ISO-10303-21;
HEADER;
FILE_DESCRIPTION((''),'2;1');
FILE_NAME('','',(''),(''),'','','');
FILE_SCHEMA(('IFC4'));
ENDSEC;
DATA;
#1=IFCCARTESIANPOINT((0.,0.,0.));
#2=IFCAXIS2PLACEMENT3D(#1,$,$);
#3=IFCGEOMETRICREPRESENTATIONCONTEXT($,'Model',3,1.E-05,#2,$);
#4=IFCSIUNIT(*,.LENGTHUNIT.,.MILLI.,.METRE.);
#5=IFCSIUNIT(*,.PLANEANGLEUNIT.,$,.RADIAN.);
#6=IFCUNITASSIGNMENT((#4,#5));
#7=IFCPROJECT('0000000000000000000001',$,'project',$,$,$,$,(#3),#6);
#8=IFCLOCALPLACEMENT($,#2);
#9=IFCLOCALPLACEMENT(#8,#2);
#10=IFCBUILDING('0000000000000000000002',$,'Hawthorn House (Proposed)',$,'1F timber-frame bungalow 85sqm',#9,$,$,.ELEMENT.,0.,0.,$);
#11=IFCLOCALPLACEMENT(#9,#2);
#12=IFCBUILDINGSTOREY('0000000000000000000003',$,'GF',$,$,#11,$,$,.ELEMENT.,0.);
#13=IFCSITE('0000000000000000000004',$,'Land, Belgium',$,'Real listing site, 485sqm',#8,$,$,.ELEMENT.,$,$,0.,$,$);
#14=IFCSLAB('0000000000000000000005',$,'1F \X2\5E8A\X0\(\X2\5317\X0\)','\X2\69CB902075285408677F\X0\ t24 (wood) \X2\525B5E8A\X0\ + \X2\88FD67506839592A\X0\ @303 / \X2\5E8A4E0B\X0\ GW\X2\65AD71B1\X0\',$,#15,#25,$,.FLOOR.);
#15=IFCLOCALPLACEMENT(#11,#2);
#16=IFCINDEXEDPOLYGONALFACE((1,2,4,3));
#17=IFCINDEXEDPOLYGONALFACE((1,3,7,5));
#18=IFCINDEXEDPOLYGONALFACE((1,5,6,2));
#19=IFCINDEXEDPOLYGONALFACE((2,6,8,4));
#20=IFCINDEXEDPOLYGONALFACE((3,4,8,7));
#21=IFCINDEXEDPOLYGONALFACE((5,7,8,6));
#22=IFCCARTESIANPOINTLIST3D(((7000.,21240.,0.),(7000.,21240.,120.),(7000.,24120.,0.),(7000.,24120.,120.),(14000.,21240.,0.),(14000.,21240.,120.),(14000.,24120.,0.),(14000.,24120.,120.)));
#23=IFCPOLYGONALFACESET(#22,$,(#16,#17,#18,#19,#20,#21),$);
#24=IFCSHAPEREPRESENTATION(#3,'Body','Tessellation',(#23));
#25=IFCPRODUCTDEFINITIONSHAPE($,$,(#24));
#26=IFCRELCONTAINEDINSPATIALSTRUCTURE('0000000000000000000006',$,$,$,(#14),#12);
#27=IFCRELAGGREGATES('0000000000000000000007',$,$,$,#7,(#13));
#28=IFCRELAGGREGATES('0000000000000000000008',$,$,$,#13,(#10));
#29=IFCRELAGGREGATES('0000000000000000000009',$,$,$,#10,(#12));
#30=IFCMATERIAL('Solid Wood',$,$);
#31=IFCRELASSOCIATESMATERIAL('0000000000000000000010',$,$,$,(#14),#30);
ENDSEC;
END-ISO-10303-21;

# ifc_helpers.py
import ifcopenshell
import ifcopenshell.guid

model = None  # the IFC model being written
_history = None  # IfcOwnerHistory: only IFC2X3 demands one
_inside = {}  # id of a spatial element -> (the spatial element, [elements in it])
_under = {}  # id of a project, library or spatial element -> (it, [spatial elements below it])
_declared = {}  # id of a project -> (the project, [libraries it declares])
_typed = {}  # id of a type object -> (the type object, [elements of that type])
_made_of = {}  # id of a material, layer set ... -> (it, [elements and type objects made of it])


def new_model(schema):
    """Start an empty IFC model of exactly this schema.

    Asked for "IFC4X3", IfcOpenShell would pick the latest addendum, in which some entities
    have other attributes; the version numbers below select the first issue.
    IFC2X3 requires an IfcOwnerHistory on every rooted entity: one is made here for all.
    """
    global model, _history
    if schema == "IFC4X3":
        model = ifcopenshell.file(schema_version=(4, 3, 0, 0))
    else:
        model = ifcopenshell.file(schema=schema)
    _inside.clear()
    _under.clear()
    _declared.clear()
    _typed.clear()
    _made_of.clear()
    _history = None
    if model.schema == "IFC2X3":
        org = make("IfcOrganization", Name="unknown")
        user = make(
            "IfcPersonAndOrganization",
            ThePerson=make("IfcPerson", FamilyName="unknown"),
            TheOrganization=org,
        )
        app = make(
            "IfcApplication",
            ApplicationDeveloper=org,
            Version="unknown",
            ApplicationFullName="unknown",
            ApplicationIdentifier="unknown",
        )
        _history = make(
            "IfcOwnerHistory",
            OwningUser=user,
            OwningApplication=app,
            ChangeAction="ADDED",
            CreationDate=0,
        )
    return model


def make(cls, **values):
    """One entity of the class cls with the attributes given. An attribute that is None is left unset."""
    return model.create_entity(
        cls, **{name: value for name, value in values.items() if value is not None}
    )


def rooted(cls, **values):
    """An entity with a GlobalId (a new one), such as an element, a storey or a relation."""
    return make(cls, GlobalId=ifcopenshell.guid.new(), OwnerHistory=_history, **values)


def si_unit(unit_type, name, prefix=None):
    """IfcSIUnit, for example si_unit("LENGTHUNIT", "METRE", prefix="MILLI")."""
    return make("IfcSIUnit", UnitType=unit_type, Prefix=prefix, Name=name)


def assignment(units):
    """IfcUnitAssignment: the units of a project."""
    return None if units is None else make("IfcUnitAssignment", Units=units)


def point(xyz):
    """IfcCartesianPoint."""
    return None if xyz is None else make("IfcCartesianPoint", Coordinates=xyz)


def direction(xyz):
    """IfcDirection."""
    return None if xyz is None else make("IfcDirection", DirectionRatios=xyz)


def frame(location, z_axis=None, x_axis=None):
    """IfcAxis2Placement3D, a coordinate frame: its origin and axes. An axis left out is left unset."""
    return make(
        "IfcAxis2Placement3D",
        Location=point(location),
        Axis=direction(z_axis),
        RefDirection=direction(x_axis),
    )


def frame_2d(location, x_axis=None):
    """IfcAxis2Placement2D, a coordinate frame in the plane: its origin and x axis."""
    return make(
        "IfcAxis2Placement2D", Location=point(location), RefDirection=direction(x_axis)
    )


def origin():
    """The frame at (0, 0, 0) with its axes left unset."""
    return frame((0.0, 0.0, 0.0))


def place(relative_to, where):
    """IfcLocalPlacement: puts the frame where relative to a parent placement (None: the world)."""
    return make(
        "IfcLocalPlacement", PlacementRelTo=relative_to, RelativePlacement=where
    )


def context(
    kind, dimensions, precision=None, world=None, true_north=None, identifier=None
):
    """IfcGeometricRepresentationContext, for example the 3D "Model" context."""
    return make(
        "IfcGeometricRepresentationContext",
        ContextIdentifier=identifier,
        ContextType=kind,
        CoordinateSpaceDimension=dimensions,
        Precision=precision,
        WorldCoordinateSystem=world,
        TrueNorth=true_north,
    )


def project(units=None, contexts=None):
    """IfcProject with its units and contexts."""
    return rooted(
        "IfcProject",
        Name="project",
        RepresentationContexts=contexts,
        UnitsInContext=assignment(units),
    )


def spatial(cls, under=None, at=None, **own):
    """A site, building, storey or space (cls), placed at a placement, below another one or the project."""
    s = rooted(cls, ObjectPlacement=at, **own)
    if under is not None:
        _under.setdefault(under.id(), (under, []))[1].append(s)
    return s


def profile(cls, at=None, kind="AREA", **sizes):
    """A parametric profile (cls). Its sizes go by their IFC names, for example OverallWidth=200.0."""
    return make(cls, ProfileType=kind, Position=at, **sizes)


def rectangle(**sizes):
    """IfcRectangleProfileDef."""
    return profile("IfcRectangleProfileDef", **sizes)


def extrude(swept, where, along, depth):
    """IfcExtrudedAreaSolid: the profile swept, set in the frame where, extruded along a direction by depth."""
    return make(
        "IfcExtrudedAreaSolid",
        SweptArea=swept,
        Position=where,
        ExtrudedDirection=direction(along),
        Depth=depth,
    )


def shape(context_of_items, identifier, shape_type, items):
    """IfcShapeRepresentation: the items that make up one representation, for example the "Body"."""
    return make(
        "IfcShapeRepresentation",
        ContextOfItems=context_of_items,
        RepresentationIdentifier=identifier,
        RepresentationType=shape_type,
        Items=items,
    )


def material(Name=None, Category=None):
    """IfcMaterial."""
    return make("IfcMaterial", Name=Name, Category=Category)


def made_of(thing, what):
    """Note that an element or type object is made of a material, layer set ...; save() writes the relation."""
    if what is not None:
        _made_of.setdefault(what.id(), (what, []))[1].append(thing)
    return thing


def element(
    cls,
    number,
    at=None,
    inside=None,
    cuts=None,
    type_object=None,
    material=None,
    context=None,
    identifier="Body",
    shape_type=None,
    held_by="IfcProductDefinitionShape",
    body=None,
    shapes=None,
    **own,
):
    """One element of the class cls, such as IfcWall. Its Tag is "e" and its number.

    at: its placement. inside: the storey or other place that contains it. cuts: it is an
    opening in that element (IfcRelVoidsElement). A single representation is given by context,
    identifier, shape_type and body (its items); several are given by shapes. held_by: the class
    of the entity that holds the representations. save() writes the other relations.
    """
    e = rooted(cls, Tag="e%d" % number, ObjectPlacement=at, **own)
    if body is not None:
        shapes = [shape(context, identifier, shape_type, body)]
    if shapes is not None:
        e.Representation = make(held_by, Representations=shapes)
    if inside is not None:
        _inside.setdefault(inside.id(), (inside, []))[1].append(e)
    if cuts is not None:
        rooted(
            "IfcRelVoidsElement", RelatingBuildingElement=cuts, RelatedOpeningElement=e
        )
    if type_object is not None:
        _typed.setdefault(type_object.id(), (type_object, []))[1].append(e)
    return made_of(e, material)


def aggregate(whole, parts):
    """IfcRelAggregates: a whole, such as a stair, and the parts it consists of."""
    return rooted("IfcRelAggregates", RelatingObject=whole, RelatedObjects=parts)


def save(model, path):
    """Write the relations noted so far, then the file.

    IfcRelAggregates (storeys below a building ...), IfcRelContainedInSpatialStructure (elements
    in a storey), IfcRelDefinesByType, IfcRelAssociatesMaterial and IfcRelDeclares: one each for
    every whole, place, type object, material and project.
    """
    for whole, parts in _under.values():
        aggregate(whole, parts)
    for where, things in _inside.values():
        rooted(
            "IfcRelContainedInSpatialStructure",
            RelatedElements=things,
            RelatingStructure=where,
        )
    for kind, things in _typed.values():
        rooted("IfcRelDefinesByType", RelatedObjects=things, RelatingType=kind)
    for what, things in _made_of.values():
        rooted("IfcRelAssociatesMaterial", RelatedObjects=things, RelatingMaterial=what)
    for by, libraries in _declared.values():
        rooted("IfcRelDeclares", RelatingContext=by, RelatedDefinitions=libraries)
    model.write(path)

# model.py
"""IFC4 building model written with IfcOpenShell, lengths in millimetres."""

from ifc_helpers import new_model, si_unit, frame, frame_2d, origin, place, context, project, spatial, rectangle, extrude, material, element, save


model = new_model("IFC4")

# Units and contexts
model_context = context("Model", 3, precision=1e-05, world=origin())
ifc_project = project(units=[si_unit("LENGTHUNIT", "METRE", prefix="MILLI"), si_unit("PLANEANGLEUNIT", "RADIAN")], contexts=[model_context])

# Site, building, storey
site_placement = place(None, origin())
site = spatial("IfcSite", under=ifc_project, at=site_placement, Name="Land, Belgium", ObjectType="Real listing site, 485sqm", CompositionType="ELEMENT", RefElevation=0.0)
building_placement = place(site_placement, origin())
building = spatial("IfcBuilding", under=site, at=building_placement, Name="Hawthorn House (Proposed)", ObjectType="1F timber-frame bungalow 85sqm", CompositionType="ELEMENT", ElevationOfRefHeight=0.0, ElevationOfTerrain=0.0)
storey_placement = place(building_placement, origin())
storey = spatial("IfcBuildingStorey", under=building, at=storey_placement, Name="GF", CompositionType="ELEMENT", Elevation=0.0)

# Slab
ifc_material_1 = material(Name="Solid Wood")
slab_1_placement = place(storey_placement, frame((3500.0, 10620.0, 0.0)))
element("IfcSlab", 1, at=slab_1_placement, inside=storey, material=ifc_material_1, Name="1F 床(北)", Description="構造用合板 t24 (wood) 剛床 + 製材根太 @303 / 床下 GW断熱", PredefinedType="FLOOR", context=model_context, shape_type="SweptSolid", body=[
    extrude(rectangle(XDim=7000.0, YDim=2880.0, at=frame_2d((3500.0, 1440.0))), frame((3500.0, 10620.0, 0.0)), (0.0, 0.0, 1.0), 120.0),
])

save(model, "model.ifc")
